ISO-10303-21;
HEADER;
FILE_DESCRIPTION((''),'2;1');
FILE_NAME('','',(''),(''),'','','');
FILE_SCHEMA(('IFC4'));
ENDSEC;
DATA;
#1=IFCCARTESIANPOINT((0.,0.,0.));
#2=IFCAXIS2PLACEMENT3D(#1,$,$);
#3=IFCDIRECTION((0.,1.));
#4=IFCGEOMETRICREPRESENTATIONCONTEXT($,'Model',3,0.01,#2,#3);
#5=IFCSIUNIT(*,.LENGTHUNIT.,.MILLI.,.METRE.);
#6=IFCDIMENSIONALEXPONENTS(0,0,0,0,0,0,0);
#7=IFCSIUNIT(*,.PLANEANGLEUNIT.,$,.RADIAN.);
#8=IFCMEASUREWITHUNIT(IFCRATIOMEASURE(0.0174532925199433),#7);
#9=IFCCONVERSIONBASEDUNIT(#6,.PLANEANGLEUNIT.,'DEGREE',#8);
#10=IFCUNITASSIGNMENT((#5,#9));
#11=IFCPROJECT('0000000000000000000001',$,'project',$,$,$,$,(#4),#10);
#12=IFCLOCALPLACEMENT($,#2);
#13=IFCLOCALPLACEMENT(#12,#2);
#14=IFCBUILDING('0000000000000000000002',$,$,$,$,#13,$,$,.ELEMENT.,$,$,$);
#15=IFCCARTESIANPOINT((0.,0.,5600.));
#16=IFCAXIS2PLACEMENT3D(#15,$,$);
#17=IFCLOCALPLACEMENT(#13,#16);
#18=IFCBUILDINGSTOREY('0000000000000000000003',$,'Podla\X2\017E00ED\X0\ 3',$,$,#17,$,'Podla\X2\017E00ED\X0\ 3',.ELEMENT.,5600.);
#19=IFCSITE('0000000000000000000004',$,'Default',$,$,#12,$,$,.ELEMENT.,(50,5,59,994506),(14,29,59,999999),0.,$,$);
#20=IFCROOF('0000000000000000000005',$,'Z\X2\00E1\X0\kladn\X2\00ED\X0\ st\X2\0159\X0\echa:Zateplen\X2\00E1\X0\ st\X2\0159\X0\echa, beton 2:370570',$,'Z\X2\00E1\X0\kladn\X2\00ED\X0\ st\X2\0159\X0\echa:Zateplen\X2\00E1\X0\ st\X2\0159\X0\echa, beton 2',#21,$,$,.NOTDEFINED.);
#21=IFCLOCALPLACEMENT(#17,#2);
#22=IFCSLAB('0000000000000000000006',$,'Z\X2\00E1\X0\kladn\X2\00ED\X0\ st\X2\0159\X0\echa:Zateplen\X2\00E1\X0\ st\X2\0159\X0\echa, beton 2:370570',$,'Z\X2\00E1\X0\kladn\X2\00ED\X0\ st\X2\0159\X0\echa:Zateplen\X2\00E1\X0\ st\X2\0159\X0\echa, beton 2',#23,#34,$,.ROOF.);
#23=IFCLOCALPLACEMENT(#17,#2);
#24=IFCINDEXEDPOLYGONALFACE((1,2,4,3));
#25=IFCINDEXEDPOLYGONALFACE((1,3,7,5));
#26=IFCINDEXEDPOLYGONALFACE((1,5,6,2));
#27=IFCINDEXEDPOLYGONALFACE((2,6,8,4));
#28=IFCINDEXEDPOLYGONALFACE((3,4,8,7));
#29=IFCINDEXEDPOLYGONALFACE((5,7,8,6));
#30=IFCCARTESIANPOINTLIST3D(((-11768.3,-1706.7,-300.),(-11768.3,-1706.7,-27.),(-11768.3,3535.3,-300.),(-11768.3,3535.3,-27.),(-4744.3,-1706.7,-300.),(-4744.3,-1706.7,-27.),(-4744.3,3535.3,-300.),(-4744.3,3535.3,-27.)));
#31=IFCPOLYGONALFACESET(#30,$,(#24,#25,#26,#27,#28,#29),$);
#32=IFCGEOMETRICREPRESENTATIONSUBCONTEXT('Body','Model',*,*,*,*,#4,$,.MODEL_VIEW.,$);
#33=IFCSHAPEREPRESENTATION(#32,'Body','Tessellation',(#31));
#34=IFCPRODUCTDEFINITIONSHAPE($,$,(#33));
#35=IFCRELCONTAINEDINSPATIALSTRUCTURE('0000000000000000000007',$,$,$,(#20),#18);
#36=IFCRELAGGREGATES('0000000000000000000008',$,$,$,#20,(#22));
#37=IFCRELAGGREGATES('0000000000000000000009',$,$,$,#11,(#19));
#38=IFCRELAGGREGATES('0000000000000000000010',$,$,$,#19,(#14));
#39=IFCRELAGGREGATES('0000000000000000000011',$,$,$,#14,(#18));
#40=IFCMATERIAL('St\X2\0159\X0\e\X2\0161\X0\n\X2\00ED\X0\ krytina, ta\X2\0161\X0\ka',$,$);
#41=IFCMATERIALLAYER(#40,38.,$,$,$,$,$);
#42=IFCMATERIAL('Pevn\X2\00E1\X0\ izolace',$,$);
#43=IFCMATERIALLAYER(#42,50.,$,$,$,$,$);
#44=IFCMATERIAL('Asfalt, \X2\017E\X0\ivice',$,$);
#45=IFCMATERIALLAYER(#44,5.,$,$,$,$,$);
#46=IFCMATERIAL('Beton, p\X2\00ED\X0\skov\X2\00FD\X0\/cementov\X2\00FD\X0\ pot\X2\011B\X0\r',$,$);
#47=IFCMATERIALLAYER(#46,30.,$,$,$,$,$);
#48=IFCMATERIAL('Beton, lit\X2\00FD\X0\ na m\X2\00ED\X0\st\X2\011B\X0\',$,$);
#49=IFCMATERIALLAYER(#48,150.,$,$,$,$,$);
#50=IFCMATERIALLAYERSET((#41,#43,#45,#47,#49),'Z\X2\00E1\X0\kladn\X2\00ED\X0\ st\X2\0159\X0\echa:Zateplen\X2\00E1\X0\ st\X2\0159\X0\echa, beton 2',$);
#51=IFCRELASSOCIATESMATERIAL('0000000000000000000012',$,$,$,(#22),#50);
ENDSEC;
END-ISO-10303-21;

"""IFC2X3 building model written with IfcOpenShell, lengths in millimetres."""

from ifc_helpers import new_model, entity, si_unit, converted_unit, direction, frame, frame_2d, origin, place, context, subcontext, project, spatial, rectangle, extrude, material, layer, layer_set, element, aggregate, save


model = new_model("IFC2X3")

# Units and contexts
model_context = context("Model", 3, precision=0.01, world=origin(), true_north=direction((0.0, 1.0)))
body_context = subcontext(model_context, "Body", "Model", "MODEL_VIEW")
ifc_project = project(units=[si_unit("LENGTHUNIT", "METRE", prefix="MILLI"), converted_unit("PLANEANGLEUNIT", "DEGREE", entity("IfcRatioMeasure", 0.0174532925199433), si_unit("PLANEANGLEUNIT", "RADIAN"), dimensions=[0, 0, 0, 0, 0, 0, 0])], contexts=[model_context])

# Site, building, storey
site_placement = place(None, origin())
site = spatial("IfcSite", under=ifc_project, at=site_placement, Name="Default", CompositionType="ELEMENT", RefLatitude=(50, 5, 59, 994506), RefLongitude=(14, 29, 59, 999999), RefElevation=0.0)
building_placement = place(site_placement, origin())
building = spatial("IfcBuilding", under=site, at=building_placement, CompositionType="ELEMENT")
storey_placement = place(building_placement, frame((0.0, 0.0, 5600.0)))
storey = spatial("IfcBuildingStorey", under=building, at=storey_placement, Name="Podlaží 3", LongName="Podlaží 3", CompositionType="ELEMENT", Elevation=5600.0)

# Roof, slab
roof_placement = place(storey_placement, frame((-11768.3, -1706.7, -300.0)))
roof = element("IfcRoof", 1, at=roof_placement, inside=storey, Name="Základní střecha:Zateplená střecha, beton 2:370570", ObjectType="Základní střecha:Zateplená střecha, beton 2", ShapeType="NOTDEFINED")
ifc_material_1 = material(Name="Střešní krytina, taška")
ifc_layer_1 = layer(ifc_material_1, 38.0)
ifc_material_2 = material(Name="Pevná izolace")
ifc_layer_2 = layer(ifc_material_2, 50.0)
ifc_material_3 = material(Name="Asfalt, živice")
ifc_layer_3 = layer(ifc_material_3, 5.0)
ifc_material_4 = material(Name="Beton, pískový/cementový potěr")
ifc_layer_4 = layer(ifc_material_4, 30.0)
ifc_material_5 = material(Name="Beton, litý na místě")
ifc_layer_5 = layer(ifc_material_5, 150.0)
ifc_layer_set = layer_set([ifc_layer_1, ifc_layer_2, ifc_layer_3, ifc_layer_4, ifc_layer_5], Name="Základní střecha:Zateplená střecha, beton 2")
slab_placement = place(roof_placement, origin())
slab = element("IfcSlab", 2, at=slab_placement, material=ifc_layer_set, Name="Základní střecha:Zateplená střecha, beton 2:370570", ObjectType="Základní střecha:Zateplená střecha, beton 2", PredefinedType="ROOF", context=body_context, shape_type="SweptSolid", body=[
    extrude(rectangle(XDim=7024.0, YDim=5242.0, at=frame_2d((0.0, 0.0), x_axis=(1.0, 0.0))), frame((3512.0, 2621.0, 0.0)), (0.0, 0.0, 1.0), 273.0),
])
aggregate(roof, [slab])

save(model, "model.ifc")
